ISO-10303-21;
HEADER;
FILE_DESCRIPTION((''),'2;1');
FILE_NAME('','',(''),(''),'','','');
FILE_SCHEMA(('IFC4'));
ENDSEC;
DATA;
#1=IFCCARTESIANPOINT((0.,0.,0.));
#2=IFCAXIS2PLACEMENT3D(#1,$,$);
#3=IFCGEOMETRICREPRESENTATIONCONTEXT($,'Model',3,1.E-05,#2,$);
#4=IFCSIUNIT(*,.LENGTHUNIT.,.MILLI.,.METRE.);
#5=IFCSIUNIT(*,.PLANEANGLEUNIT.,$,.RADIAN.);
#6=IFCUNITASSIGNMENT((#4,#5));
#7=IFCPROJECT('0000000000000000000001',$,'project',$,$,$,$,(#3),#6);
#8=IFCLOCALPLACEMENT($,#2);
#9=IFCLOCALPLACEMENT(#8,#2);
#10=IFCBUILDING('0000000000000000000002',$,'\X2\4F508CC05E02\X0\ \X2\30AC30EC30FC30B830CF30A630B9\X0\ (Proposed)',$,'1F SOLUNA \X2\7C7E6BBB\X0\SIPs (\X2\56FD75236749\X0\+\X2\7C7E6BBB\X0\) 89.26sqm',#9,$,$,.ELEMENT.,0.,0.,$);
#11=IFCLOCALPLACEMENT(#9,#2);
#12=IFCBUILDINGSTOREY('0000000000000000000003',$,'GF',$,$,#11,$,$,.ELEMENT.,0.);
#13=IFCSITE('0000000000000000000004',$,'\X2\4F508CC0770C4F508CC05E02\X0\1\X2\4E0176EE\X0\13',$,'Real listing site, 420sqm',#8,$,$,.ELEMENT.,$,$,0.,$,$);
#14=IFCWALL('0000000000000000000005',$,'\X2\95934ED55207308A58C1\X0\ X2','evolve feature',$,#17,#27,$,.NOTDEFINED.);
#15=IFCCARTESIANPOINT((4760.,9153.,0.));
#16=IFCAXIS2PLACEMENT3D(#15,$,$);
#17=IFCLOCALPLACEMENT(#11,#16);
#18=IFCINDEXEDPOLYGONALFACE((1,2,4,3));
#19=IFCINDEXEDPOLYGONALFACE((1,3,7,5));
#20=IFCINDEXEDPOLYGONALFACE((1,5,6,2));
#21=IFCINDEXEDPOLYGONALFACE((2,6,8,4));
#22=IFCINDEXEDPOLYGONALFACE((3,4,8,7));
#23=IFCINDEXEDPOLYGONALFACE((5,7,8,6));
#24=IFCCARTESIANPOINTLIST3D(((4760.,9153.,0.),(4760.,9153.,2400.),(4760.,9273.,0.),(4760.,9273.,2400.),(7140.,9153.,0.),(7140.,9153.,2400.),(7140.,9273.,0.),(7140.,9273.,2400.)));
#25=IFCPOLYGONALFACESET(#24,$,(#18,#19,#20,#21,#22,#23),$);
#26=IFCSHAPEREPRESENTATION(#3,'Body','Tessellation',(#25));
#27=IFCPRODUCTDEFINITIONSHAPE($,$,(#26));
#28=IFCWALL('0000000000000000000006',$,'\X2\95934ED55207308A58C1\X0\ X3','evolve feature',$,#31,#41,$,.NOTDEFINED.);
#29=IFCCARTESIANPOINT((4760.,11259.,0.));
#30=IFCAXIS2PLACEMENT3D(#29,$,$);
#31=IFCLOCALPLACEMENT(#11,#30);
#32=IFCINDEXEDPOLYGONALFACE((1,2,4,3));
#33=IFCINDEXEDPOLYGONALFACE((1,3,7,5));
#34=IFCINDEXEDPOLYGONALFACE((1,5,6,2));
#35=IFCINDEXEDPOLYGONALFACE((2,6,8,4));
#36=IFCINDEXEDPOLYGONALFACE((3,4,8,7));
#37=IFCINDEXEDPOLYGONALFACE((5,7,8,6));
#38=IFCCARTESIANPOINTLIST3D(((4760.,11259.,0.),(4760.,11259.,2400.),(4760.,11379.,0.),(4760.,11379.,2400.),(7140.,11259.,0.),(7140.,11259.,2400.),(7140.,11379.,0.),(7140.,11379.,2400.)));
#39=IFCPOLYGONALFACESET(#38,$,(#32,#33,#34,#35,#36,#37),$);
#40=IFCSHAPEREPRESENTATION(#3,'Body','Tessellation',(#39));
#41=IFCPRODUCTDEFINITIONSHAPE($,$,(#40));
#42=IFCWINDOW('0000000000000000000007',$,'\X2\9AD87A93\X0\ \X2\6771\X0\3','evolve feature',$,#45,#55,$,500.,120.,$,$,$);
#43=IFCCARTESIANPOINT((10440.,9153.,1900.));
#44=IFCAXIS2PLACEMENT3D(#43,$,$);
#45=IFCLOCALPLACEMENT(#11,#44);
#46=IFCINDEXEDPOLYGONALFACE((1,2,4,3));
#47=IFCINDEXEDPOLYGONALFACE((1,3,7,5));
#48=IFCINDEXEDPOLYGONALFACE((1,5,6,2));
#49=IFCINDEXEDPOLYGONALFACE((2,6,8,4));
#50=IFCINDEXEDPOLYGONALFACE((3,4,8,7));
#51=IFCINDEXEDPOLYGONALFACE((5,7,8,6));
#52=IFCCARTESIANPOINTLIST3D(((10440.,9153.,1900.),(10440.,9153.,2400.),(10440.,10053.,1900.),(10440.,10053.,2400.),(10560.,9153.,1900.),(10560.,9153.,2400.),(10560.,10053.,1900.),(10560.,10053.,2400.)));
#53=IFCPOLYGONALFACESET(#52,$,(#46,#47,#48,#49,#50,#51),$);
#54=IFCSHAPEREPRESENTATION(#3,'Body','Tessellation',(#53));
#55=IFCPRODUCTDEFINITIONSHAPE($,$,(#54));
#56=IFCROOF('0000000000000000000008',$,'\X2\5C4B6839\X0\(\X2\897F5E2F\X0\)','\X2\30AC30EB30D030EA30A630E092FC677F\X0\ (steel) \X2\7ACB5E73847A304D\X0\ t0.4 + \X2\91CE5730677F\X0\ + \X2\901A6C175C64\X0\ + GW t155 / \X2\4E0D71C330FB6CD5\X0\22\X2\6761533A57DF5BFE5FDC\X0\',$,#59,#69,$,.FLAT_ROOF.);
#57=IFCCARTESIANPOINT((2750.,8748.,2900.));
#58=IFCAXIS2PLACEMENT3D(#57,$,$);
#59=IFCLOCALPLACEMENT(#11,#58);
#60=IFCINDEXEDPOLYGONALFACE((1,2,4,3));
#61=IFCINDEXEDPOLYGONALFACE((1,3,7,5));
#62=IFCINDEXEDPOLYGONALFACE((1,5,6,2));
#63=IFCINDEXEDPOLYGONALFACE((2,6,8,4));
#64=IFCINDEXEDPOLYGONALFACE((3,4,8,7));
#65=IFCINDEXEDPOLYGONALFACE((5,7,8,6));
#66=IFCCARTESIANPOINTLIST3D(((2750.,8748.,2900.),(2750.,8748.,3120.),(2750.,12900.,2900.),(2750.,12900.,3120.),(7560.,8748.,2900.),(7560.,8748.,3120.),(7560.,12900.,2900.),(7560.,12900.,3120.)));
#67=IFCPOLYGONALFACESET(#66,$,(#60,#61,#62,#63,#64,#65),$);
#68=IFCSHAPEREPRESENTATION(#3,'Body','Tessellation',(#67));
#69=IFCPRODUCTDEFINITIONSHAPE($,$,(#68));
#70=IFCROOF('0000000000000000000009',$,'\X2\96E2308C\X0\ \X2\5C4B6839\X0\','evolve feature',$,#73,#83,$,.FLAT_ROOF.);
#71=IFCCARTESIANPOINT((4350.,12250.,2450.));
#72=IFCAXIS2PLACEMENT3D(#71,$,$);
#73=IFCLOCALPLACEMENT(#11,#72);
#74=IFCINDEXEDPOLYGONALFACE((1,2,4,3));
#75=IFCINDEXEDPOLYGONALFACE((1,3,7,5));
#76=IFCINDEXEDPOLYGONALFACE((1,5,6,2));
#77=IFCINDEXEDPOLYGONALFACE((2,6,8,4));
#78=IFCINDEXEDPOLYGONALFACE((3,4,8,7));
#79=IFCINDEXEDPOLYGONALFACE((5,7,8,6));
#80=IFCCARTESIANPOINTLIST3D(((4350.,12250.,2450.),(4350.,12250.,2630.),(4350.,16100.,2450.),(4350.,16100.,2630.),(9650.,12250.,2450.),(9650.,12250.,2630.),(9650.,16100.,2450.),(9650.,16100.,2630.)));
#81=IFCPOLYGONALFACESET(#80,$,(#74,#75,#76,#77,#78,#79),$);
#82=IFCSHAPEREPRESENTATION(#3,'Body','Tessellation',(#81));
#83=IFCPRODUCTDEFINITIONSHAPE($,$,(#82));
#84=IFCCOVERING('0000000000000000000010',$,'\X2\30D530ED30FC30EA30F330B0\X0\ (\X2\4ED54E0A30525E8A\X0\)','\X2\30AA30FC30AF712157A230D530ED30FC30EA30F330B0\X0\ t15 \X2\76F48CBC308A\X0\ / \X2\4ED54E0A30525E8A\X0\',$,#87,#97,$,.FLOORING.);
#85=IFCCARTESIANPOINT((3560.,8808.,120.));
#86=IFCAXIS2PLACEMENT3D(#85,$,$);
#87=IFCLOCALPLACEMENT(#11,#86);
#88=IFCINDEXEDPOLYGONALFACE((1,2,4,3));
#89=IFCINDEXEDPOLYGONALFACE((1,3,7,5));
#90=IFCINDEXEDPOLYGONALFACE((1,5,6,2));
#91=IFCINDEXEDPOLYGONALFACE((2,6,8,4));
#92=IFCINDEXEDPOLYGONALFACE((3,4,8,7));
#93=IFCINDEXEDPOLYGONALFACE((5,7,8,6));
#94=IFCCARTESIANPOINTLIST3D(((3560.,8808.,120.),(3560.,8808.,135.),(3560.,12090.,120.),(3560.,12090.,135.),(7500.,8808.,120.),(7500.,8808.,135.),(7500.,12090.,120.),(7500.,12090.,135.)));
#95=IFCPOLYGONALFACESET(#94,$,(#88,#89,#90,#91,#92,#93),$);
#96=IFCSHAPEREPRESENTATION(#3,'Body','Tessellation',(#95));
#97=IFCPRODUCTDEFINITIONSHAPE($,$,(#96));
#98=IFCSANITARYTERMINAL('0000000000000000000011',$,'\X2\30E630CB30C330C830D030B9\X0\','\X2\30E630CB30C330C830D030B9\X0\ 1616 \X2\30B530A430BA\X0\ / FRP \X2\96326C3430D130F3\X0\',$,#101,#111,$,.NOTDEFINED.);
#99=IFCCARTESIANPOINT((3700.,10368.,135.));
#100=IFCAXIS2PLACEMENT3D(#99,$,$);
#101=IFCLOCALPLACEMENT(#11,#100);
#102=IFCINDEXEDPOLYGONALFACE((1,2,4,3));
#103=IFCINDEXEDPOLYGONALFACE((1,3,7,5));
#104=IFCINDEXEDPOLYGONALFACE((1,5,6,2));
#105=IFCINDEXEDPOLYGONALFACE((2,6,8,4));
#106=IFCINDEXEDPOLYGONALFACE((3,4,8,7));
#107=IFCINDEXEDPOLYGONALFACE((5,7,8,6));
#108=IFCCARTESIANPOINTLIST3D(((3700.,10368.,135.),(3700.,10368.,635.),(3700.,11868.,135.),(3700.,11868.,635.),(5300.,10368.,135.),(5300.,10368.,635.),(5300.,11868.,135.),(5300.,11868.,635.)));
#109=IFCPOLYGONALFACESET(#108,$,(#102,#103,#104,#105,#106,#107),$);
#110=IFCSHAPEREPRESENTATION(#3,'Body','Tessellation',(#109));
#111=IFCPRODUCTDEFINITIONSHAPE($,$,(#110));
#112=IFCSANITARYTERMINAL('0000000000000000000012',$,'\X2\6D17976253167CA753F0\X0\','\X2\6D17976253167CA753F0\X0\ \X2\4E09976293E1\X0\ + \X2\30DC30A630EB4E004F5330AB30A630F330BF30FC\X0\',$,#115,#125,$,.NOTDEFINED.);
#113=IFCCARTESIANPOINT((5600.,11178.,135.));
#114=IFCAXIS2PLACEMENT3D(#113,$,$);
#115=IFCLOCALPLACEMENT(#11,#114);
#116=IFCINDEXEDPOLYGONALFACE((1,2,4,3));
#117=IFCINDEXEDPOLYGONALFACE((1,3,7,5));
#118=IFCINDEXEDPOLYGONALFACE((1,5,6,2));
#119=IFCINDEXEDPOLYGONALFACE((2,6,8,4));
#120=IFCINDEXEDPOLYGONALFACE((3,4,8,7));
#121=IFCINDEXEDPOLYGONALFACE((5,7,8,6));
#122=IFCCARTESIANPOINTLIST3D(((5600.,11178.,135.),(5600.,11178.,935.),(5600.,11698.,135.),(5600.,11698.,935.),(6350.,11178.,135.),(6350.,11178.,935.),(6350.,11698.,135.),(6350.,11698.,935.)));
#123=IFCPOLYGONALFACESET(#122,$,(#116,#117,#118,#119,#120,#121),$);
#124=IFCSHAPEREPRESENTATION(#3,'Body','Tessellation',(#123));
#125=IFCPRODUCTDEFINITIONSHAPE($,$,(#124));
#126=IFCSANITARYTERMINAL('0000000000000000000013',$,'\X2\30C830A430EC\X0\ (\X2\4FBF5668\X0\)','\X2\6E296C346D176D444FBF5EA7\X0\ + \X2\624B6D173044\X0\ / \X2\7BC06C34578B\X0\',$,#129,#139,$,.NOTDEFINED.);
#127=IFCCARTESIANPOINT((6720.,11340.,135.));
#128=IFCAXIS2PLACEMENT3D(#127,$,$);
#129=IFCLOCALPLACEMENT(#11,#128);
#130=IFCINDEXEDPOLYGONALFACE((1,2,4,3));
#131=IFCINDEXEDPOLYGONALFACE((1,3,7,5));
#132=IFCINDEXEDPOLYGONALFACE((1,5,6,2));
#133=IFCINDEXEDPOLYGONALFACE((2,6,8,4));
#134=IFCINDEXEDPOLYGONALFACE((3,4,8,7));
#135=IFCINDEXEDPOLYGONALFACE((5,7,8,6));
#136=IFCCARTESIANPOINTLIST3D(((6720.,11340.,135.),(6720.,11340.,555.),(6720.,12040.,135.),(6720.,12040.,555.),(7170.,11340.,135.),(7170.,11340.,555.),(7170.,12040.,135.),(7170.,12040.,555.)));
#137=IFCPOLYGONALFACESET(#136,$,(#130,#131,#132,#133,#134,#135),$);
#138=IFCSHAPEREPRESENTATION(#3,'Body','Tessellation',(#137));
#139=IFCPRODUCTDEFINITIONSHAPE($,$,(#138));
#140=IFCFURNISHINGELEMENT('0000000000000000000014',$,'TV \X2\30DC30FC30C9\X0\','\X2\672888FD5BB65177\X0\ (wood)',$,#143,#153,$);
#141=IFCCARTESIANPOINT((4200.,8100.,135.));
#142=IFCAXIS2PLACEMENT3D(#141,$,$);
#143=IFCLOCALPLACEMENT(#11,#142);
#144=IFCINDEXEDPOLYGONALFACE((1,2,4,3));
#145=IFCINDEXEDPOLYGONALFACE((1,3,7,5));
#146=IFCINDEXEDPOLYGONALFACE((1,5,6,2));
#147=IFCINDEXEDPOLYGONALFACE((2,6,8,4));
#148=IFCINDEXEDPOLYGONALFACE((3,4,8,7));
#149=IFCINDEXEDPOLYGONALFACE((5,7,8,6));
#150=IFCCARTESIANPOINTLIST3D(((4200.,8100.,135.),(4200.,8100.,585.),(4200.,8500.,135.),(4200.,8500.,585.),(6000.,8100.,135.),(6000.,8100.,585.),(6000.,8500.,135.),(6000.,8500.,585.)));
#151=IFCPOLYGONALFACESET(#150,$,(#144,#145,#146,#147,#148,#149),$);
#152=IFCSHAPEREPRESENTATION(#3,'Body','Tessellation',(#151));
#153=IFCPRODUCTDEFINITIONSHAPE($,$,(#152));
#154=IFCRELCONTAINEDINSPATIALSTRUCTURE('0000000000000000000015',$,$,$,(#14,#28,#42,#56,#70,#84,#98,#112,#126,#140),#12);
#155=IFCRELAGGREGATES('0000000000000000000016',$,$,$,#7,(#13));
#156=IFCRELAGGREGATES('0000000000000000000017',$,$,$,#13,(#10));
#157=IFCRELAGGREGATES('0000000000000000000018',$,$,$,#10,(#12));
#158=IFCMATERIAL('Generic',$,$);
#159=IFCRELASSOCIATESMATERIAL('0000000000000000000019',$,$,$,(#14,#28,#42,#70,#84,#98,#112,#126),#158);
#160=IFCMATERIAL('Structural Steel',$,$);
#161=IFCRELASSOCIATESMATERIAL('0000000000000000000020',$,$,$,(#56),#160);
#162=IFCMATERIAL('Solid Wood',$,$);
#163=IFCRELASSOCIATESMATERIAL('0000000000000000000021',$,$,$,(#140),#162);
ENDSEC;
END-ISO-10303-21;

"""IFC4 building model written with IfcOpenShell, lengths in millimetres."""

from ifc_helpers import new_model, si_unit, frame, frame_2d, origin, place, context, project, spatial, rectangle, extrude, material, element, save


model = new_model("IFC4")

# Units and contexts
model_context = context("Model", 3, precision=1e-05, world=origin())
ifc_project = project(units=[si_unit("LENGTHUNIT", "METRE", prefix="MILLI"), si_unit("PLANEANGLEUNIT", "RADIAN")], contexts=[model_context])

# Site, building, storey
site_placement = place(None, origin())
site = spatial("IfcSite", under=ifc_project, at=site_placement, Name="佐賀県佐賀市1丁目13", ObjectType="Real listing site, 420sqm", CompositionType="ELEMENT", RefElevation=0.0)
building_placement = place(site_placement, origin())
building = spatial("IfcBuilding", under=site, at=building_placement, Name="佐賀市 ガレージハウス (Proposed)", ObjectType="1F SOLUNA 籾殻SIPs (国産杉+籾殻) 89.26sqm", CompositionType="ELEMENT", ElevationOfRefHeight=0.0, ElevationOfTerrain=0.0)
storey_placement = place(building_placement, origin())
storey = spatial("IfcBuildingStorey", under=building, at=storey_placement, Name="GF", CompositionType="ELEMENT", Elevation=0.0)

# Shared definitions
ifc_material_1 = material(Name="Solid Wood")
ifc_material_2 = material(Name="Generic")

# Walls
wall_1_placement = place(storey_placement, frame((4760.0, 9153.0, 0.0)))
element("IfcWall", 1, at=wall_1_placement, inside=storey, material=ifc_material_2, Name="間仕切り壁 X2", Description="evolve feature", PredefinedType="NOTDEFINED", context=model_context, shape_type="SweptSolid", body=[
    extrude(rectangle(XDim=2380.0, YDim=120.0, at=frame_2d((1190.0, 60.0))), frame((4760.0, 9153.0, 0.0)), (0.0, 0.0, 1.0), 2400.0),
])
wall_2_placement = place(storey_placement, frame((4760.0, 11259.0, 0.0)))
element("IfcWall", 2, at=wall_2_placement, inside=storey, material=ifc_material_2, Name="間仕切り壁 X3", Description="evolve feature", PredefinedType="NOTDEFINED", context=model_context, shape_type="SweptSolid", body=[
    extrude(rectangle(XDim=2380.0, YDim=120.0, at=frame_2d((1190.0, 60.0))), frame((4760.0, 11259.0, 0.0)), (0.0, 0.0, 1.0), 2400.0),
])

# Window
window_1_placement = place(storey_placement, frame((10440.0, 9153.0, 1900.0)))
element("IfcWindow", 3, at=window_1_placement, inside=storey, material=ifc_material_2, Name="高窓 東3", Description="evolve feature", OverallHeight=500.0, OverallWidth=120.0, context=model_context, shape_type="SweptSolid", body=[
    extrude(rectangle(XDim=120.0, YDim=900.0, at=frame_2d((60.0, 450.0))), frame((10440.0, 9153.0, 1900.0)), (0.0, 0.0, 1.0), 500.0),
])

# Roofs
ifc_material_3 = material(Name="Structural Steel")
roof_1_placement = place(storey_placement, frame((2750.0, 8748.0, 2900.0)))
element("IfcRoof", 4, at=roof_1_placement, inside=storey, material=ifc_material_3, Name="屋根(西帯)", Description="ガルバリウム鋼板 (steel) 立平葺き t0.4 + 野地板 + 通気層 + GW t155 / 不燃・法22条区域対応", PredefinedType="FLAT_ROOF", context=model_context, shape_type="SweptSolid", body=[
    extrude(rectangle(XDim=4810.0, YDim=4152.0, at=frame_2d((2405.0, 2076.0))), frame((2750.0, 8748.0, 2900.0)), (0.0, 0.0, 1.0), 220.0),
])
roof_2_placement = place(storey_placement, frame((4350.0, 12250.0, 2450.0)))
element("IfcRoof", 5, at=roof_2_placement, inside=storey, material=ifc_material_2, Name="離れ 屋根", Description="evolve feature", PredefinedType="FLAT_ROOF", context=model_context, shape_type="SweptSolid", body=[
    extrude(rectangle(XDim=5300.0, YDim=3850.0, at=frame_2d((2650.0, 1925.0))), frame((4350.0, 12250.0, 2450.0)), (0.0, 0.0, 1.0), 180.0),
])

# Covering
covering_placement = place(storey_placement, frame((3560.0, 8808.0, 120.0)))
element("IfcCovering", 6, at=covering_placement, inside=storey, material=ifc_material_2, Name="フローリング (仕上げ床)", Description="オーク無垢フローリング t15 直貼り / 仕上げ床", PredefinedType="FLOORING", context=model_context, shape_type="SweptSolid", body=[
    extrude(rectangle(XDim=3940.0, YDim=3282.0, at=frame_2d((1970.0, 1641.0))), frame((3560.0, 8808.0, 120.0)), (0.0, 0.0, 1.0), 15.0),
])

# Sanitary terminals
sanitary_terminal_1_placement = place(storey_placement, frame((3700.0, 10368.0, 135.0)))
element("IfcSanitaryTerminal", 7, at=sanitary_terminal_1_placement, inside=storey, material=ifc_material_2, Name="ユニットバス", Description="ユニットバス 1616 サイズ / FRP 防水パン", PredefinedType="NOTDEFINED", context=model_context, shape_type="SweptSolid", body=[
    extrude(rectangle(XDim=1600.0, YDim=1500.0, at=frame_2d((800.0, 750.0))), frame((3700.0, 10368.0, 135.0)), (0.0, 0.0, 1.0), 500.0),
])
sanitary_terminal_2_placement = place(storey_placement, frame((5600.0, 11178.0, 135.0)))
element("IfcSanitaryTerminal", 8, at=sanitary_terminal_2_placement, inside=storey, material=ifc_material_2, Name="洗面化粧台", Description="洗面化粧台 三面鏡 + ボウル一体カウンター", PredefinedType="NOTDEFINED", context=model_context, shape_type="SweptSolid", body=[
    extrude(rectangle(XDim=750.0, YDim=520.0, at=frame_2d((375.0, 260.0))), frame((5600.0, 11178.0, 135.0)), (0.0, 0.0, 1.0), 800.0),
])
sanitary_terminal_3_placement = place(storey_placement, frame((6720.0, 11340.0, 135.0)))
element("IfcSanitaryTerminal", 9, at=sanitary_terminal_3_placement, inside=storey, material=ifc_material_2, Name="トイレ (便器)", Description="温水洗浄便座 + 手洗い / 節水型", PredefinedType="NOTDEFINED", context=model_context, shape_type="SweptSolid", body=[
    extrude(rectangle(XDim=450.0, YDim=700.0, at=frame_2d((225.0, 350.0))), frame((6720.0, 11340.0, 135.0)), (0.0, 0.0, 1.0), 420.0),
])

# Furnishing element
furnishing_placement = place(storey_placement, frame((4200.0, 8100.0, 135.0)))
element("IfcFurnishingElement", 10, at=furnishing_placement, inside=storey, material=ifc_material_1, Name="TV ボード", Description="木製家具 (wood)", context=model_context, shape_type="SweptSolid", body=[
    extrude(rectangle(XDim=1800.0, YDim=400.0, at=frame_2d((900.0, 200.0))), frame((4200.0, 8100.0, 135.0)), (0.0, 0.0, 1.0), 450.0),
])

save(model, "model.ifc")
